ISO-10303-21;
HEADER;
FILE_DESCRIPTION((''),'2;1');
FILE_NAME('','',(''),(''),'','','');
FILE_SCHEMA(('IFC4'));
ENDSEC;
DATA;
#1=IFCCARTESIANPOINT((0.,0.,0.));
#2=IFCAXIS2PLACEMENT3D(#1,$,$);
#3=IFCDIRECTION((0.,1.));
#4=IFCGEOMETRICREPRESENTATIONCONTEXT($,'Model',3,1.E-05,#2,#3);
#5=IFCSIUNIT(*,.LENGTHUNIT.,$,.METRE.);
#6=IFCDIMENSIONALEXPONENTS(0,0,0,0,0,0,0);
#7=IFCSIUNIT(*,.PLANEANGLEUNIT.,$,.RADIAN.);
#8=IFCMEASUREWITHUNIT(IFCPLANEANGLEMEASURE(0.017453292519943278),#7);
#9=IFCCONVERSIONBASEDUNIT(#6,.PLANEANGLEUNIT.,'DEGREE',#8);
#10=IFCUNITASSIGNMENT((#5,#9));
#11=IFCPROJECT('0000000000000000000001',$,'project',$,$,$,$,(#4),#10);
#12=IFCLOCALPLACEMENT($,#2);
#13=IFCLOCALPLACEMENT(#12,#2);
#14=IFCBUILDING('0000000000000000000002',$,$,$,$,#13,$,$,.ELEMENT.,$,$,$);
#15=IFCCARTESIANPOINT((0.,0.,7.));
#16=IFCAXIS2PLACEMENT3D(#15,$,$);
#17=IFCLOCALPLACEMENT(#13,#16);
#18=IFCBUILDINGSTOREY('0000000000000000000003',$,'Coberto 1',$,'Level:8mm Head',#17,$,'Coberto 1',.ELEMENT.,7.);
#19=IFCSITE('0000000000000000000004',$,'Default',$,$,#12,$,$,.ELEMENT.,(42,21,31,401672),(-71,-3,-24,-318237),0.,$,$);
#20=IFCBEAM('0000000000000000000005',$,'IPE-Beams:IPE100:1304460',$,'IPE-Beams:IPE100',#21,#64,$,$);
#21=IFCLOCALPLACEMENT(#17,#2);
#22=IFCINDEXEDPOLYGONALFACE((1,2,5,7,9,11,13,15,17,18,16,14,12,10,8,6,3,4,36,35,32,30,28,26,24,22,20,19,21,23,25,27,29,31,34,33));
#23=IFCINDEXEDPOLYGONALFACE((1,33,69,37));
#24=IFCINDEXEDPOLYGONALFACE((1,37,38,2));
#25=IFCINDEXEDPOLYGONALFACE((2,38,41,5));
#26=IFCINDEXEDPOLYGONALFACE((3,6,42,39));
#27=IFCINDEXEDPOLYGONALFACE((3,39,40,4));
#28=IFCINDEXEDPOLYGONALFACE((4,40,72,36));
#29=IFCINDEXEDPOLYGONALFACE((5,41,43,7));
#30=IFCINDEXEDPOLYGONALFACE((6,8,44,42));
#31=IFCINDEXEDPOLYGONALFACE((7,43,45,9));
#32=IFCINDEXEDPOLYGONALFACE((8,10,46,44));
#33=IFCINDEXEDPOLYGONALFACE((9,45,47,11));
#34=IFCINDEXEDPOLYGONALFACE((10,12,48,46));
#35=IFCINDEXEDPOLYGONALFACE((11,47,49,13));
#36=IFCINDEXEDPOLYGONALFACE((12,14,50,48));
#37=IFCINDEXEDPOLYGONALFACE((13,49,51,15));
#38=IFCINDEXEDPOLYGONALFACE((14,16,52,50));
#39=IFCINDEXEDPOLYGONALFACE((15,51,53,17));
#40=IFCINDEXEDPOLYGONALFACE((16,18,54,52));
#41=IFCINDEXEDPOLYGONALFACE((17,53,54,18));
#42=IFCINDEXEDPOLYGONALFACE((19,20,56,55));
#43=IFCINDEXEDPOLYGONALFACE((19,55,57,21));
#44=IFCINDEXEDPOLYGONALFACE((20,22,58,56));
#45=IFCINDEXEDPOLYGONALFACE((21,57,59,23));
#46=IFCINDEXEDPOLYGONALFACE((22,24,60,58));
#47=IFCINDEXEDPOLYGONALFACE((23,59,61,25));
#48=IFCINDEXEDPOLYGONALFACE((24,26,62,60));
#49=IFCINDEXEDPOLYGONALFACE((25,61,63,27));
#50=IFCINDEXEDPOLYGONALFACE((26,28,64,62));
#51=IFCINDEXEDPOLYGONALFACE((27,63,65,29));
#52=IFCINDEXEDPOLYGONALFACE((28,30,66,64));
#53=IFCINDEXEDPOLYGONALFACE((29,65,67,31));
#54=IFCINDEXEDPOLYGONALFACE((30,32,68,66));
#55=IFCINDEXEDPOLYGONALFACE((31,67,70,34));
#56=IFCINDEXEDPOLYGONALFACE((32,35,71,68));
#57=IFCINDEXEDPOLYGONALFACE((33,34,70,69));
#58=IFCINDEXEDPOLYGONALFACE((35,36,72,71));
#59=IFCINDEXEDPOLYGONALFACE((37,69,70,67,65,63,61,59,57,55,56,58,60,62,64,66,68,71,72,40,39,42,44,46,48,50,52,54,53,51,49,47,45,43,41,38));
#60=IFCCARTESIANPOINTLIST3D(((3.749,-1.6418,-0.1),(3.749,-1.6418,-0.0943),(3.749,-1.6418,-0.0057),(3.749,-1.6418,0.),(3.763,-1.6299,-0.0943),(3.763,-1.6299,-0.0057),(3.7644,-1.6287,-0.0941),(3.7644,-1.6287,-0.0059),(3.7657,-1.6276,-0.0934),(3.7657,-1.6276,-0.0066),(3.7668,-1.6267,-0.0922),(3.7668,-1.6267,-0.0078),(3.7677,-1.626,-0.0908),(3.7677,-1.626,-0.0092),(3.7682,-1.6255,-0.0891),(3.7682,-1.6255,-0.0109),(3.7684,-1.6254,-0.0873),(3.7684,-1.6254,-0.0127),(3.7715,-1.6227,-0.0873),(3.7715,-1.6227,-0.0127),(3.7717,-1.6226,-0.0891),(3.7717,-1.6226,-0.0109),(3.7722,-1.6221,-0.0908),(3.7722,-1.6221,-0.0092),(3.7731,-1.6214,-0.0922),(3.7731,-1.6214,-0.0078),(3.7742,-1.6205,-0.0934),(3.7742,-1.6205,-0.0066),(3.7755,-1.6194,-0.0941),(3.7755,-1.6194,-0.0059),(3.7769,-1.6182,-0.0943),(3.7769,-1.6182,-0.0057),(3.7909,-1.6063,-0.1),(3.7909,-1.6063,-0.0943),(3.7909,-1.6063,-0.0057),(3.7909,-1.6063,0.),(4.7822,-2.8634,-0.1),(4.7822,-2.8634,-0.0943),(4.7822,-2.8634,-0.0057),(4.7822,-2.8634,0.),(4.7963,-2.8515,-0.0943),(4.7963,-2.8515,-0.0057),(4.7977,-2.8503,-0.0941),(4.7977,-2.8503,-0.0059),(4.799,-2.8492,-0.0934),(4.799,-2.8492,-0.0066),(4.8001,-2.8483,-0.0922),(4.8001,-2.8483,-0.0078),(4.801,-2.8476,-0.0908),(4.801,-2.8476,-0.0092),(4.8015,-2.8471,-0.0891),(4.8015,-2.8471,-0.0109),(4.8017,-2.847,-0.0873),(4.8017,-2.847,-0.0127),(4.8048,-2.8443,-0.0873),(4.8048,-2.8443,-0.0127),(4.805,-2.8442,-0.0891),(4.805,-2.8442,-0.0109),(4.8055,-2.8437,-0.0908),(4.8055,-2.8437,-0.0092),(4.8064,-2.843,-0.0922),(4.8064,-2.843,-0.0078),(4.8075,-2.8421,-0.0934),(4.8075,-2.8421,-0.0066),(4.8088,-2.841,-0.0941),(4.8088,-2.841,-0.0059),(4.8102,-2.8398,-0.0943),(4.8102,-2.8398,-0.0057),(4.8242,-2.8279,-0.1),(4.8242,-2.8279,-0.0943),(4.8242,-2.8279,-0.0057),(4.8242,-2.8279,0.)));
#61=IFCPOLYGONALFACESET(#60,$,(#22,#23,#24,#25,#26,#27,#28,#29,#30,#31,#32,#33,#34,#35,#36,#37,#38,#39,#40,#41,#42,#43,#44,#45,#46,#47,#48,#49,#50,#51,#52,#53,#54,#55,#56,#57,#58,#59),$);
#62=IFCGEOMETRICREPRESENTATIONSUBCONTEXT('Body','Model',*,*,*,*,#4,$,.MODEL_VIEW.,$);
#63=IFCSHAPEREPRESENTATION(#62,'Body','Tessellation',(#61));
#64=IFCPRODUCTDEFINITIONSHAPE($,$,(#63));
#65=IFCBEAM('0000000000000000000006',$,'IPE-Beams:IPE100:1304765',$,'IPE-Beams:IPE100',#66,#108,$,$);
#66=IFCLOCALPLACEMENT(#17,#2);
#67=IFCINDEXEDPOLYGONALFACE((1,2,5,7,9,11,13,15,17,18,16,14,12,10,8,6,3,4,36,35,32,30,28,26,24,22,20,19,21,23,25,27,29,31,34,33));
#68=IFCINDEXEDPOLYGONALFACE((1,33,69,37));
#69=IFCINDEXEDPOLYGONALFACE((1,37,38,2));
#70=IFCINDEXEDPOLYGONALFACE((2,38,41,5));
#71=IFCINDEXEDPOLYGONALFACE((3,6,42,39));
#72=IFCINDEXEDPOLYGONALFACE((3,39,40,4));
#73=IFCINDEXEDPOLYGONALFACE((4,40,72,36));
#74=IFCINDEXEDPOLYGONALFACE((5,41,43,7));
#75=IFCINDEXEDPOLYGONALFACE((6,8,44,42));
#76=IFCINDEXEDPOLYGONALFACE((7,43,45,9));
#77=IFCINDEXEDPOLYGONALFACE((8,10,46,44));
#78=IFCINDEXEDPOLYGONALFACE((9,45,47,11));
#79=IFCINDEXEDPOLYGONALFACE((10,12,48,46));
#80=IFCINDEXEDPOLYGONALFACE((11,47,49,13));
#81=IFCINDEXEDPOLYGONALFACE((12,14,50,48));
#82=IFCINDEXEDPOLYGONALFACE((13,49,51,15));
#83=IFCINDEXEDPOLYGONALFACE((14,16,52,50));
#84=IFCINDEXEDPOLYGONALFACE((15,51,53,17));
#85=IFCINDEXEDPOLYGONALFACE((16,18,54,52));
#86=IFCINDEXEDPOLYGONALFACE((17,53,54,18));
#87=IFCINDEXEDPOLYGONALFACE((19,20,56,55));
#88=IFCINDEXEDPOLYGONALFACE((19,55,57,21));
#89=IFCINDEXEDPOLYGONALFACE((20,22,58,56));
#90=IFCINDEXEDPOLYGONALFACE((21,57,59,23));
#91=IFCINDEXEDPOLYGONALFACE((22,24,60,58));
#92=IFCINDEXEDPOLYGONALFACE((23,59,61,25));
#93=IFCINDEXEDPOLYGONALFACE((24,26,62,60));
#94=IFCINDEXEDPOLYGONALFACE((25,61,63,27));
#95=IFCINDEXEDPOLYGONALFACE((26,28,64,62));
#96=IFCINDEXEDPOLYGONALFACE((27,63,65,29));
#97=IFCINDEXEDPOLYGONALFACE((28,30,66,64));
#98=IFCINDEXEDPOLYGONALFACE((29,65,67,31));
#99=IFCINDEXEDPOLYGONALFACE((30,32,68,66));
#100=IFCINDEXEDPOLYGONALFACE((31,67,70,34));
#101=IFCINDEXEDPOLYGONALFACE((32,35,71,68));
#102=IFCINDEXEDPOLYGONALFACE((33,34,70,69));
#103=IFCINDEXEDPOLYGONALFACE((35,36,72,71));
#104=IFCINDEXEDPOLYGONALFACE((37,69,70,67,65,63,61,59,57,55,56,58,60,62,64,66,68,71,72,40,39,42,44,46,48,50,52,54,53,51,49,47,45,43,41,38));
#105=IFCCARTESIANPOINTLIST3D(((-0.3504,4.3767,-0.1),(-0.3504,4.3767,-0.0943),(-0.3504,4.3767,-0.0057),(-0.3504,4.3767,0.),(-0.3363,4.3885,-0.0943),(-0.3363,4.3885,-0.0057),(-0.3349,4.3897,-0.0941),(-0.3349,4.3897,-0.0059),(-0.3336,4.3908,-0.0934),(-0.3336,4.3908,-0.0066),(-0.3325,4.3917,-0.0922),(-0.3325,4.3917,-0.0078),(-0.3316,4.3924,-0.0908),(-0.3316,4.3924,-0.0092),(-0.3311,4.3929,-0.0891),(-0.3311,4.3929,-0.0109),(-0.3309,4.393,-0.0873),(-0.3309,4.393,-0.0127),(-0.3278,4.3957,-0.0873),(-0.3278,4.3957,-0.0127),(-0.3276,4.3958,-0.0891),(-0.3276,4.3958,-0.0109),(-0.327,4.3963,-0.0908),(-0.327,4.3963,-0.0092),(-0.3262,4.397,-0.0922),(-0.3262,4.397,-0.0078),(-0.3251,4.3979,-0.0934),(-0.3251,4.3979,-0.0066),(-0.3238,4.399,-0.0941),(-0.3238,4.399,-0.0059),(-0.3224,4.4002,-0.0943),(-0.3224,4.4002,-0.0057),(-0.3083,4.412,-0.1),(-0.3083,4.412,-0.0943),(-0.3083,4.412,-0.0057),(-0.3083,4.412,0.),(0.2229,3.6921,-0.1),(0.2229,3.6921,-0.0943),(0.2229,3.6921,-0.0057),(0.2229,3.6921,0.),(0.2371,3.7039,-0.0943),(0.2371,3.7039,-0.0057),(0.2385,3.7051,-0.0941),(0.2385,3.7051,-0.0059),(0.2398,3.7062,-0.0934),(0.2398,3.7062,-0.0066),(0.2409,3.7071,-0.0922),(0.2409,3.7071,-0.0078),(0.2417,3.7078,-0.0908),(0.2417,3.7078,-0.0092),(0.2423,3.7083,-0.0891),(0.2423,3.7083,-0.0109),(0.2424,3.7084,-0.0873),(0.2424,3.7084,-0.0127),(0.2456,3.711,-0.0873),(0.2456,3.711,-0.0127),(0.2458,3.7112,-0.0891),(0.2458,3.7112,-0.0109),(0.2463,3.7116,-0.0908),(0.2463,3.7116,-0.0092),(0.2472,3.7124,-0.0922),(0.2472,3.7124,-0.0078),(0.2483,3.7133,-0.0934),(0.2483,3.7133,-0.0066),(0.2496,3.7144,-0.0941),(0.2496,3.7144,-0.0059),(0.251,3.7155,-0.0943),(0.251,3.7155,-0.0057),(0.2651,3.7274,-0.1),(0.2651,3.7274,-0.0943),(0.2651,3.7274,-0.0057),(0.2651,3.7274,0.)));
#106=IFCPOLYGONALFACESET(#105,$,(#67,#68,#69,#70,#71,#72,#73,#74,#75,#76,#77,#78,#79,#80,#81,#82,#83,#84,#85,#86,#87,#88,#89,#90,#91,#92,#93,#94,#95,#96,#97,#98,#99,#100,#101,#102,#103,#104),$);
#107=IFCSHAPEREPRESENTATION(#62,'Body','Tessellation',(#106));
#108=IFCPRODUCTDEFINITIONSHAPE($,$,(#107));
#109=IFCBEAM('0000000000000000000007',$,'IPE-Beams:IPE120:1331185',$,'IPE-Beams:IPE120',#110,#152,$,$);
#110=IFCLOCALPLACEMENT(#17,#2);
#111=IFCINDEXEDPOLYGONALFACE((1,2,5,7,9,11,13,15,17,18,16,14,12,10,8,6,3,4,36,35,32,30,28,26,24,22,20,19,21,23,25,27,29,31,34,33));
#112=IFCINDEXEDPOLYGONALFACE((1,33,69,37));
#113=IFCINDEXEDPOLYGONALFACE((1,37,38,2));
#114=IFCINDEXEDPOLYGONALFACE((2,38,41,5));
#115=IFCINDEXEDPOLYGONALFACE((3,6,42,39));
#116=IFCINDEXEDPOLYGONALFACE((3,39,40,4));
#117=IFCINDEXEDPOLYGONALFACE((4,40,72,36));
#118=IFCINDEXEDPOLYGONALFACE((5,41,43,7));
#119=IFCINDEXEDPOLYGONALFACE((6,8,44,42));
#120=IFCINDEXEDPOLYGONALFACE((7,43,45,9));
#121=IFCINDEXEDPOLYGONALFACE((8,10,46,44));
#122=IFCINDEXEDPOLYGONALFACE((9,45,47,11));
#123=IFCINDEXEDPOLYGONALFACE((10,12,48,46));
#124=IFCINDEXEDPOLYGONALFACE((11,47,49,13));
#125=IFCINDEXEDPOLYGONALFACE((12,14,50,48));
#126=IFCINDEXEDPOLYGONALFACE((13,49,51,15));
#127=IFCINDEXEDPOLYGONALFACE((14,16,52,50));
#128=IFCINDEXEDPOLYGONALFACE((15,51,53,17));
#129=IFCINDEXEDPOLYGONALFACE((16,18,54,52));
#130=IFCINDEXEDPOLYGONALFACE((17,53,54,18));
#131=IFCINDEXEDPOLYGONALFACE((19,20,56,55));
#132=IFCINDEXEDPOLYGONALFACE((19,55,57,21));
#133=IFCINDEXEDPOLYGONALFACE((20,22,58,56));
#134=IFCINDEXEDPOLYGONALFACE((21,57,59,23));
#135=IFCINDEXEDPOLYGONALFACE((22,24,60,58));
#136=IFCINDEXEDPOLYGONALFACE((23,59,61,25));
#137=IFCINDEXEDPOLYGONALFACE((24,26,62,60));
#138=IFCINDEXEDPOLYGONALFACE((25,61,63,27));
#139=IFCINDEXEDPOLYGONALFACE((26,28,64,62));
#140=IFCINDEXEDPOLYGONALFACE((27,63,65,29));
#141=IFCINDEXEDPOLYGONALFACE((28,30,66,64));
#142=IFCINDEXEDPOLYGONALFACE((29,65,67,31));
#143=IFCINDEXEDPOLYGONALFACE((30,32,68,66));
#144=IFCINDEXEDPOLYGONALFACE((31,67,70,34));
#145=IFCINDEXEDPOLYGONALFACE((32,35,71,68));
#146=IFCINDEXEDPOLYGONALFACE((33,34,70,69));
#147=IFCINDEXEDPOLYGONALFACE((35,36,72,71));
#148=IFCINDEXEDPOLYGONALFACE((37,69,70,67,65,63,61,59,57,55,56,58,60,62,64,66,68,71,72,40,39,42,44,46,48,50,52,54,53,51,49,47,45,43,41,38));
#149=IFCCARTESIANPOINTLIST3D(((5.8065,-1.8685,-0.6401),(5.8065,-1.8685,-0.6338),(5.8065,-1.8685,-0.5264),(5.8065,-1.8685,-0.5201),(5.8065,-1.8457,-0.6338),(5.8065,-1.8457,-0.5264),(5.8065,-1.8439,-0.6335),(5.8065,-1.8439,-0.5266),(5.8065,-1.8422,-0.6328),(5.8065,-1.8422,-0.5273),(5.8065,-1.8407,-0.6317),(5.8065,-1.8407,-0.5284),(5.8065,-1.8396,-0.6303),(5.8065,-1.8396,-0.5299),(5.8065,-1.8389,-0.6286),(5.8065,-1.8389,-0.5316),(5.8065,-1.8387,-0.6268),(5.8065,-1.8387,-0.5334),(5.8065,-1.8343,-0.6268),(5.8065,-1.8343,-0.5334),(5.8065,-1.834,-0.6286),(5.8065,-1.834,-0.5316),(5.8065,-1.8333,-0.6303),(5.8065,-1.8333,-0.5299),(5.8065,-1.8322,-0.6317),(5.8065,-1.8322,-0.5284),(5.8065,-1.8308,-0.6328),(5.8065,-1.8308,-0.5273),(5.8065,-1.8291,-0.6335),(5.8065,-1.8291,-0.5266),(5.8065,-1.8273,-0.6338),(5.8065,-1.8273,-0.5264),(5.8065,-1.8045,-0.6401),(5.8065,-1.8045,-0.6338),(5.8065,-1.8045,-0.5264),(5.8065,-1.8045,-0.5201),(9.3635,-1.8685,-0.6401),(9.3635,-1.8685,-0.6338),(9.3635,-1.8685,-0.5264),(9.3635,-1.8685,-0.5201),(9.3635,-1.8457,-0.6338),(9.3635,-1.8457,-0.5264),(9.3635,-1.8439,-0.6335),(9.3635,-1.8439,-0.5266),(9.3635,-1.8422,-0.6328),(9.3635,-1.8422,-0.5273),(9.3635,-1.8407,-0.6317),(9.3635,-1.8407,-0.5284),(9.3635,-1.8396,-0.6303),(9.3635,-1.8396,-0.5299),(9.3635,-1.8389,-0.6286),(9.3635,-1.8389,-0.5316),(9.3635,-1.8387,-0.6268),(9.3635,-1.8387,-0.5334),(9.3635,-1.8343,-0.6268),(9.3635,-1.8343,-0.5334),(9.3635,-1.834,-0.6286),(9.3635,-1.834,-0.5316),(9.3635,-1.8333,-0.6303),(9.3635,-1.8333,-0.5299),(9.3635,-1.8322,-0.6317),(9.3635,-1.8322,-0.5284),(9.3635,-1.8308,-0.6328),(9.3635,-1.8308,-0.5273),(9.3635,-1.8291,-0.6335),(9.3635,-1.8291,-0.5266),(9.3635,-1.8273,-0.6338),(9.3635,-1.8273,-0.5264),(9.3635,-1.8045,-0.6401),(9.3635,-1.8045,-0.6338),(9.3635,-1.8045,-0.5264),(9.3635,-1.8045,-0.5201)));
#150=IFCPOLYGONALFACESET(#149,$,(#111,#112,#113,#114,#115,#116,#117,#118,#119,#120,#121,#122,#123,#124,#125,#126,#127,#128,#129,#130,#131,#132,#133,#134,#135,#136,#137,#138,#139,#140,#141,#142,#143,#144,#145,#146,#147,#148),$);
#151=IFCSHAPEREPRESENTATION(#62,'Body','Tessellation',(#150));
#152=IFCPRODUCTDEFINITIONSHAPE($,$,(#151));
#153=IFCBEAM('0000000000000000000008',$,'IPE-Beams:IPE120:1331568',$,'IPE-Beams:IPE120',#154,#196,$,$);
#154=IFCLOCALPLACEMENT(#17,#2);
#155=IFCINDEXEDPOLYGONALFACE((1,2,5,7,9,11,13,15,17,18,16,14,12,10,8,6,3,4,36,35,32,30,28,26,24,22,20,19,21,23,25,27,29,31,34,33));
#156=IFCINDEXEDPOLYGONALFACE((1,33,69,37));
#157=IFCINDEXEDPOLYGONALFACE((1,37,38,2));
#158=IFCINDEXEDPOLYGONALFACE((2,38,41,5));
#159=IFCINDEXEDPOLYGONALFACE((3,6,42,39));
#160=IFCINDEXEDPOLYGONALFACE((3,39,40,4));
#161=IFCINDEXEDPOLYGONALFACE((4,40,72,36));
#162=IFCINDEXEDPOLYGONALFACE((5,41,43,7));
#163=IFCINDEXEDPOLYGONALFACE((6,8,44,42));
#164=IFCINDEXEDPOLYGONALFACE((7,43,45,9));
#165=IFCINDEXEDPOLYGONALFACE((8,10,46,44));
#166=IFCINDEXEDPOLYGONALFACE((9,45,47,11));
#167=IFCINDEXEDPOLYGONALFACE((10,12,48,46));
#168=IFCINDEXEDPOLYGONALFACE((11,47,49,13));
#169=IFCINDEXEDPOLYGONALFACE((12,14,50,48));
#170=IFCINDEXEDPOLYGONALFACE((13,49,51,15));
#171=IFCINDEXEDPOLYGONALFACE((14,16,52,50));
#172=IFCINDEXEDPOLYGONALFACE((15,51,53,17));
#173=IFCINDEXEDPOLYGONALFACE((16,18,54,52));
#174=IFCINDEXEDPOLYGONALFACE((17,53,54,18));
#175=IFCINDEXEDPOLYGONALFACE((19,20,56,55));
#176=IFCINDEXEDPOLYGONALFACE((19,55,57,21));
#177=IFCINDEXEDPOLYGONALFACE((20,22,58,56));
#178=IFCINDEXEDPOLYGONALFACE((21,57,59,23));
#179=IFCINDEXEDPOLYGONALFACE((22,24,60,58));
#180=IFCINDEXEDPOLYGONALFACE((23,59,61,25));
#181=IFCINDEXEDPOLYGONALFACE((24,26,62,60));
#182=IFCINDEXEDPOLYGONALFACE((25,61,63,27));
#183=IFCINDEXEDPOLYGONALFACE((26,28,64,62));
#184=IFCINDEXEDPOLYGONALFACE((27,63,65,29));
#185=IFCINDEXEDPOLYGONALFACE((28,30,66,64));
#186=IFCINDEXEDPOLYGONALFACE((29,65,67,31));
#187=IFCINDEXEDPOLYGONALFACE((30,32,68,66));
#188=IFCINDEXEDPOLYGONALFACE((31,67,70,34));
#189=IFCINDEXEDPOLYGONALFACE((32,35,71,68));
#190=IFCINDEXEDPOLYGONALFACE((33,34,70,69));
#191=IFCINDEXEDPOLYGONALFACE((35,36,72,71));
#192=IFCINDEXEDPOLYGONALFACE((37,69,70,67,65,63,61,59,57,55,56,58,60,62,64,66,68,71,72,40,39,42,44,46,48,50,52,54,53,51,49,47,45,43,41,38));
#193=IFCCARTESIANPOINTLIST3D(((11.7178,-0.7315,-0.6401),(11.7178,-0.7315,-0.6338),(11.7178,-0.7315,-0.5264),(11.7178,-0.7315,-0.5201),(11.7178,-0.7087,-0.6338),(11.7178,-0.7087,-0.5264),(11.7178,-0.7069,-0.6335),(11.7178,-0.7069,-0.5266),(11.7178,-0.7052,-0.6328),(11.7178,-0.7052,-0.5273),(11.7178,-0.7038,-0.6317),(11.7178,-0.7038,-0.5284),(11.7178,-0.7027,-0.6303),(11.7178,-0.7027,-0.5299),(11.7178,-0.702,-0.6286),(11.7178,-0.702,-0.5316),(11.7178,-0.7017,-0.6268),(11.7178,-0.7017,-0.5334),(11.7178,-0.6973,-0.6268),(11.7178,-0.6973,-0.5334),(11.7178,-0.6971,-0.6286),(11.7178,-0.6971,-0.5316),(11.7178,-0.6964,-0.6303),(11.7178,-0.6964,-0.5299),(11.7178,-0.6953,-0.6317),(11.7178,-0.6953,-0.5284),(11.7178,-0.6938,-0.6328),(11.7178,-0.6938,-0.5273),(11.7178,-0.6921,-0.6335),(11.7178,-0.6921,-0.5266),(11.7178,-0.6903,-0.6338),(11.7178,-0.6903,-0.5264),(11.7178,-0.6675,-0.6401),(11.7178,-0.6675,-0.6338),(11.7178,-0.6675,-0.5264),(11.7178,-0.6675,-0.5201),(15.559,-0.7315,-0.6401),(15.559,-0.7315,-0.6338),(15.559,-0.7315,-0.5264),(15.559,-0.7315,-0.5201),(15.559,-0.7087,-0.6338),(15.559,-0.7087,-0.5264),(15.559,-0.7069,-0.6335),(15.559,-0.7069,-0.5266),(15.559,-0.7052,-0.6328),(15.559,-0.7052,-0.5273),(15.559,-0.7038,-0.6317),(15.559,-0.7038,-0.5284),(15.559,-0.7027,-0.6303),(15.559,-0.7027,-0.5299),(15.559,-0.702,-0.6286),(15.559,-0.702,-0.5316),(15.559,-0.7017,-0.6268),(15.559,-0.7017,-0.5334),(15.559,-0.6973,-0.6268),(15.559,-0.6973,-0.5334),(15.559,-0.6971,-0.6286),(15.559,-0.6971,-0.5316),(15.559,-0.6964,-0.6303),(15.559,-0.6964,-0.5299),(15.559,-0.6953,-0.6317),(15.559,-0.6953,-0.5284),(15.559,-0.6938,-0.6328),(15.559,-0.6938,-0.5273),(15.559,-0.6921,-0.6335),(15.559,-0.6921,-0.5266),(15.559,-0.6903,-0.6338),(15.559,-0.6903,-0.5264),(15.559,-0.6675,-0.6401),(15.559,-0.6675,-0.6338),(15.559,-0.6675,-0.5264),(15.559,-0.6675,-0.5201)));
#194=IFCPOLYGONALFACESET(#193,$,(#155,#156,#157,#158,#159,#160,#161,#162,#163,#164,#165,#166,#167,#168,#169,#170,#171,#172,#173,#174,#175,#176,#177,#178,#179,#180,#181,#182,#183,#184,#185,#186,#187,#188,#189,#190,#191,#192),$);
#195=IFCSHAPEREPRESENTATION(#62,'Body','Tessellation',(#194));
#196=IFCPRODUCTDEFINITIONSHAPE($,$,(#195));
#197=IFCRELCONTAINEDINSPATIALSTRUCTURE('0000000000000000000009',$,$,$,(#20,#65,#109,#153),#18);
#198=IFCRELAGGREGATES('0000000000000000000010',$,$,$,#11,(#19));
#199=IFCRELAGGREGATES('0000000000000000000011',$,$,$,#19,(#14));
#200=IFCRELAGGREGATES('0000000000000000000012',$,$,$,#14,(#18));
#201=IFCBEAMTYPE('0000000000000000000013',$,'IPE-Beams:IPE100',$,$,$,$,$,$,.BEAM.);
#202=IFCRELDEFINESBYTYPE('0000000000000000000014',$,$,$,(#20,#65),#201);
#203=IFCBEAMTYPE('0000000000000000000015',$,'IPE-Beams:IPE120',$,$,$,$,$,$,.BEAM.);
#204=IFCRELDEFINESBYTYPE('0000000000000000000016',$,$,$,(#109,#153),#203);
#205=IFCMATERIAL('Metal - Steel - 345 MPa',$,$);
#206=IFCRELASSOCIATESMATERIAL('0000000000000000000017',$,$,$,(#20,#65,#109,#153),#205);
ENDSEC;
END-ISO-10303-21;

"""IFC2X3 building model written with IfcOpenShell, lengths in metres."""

from ifc_helpers import new_model, entity, si_unit, converted_unit, direction, frame, frame_2d, origin, place, context, subcontext, project, spatial, i_section, extrude, material, type_object, element, save


model = new_model("IFC2X3")

# Units and contexts
model_context = context("Model", 3, precision=1e-05, world=origin(), true_north=direction((0.0, 1.0)))
body_context = subcontext(model_context, "Body", "Model", "MODEL_VIEW")
ifc_project = project(units=[si_unit("LENGTHUNIT", "METRE"), converted_unit("PLANEANGLEUNIT", "DEGREE", entity("IfcPlaneAngleMeasure", 0.017453292519943278), si_unit("PLANEANGLEUNIT", "RADIAN"), dimensions=[0, 0, 0, 0, 0, 0, 0])], contexts=[model_context])

# Site, building, storey
site_placement = place(None, origin())
site = spatial("IfcSite", under=ifc_project, at=site_placement, Name="Default", CompositionType="ELEMENT", RefLatitude=(42, 21, 31, 401672), RefLongitude=(-71, -3, -24, -318237), RefElevation=0.0)
building_placement = place(site_placement, origin())
building = spatial("IfcBuilding", under=site, at=building_placement, CompositionType="ELEMENT")
storey_placement = place(building_placement, frame((0.0, 0.0, 7.0)))
storey = spatial("IfcBuildingStorey", under=building, at=storey_placement, Name="Coberto 1", ObjectType="Level:8mm Head", LongName="Coberto 1", CompositionType="ELEMENT", Elevation=7.0)

# Shared definitions
ifc_material_1 = material(Name="Metal - Steel - 345 MPa")

# Beams
beam_type_1 = type_object("IfcBeamType", Name="IPE-Beams:IPE100", PredefinedType="BEAM")
beam_1_placement = place(storey_placement, frame((3.7067, -1.5493, 0.0), z_axis=(0.0, 0.0, 1.0), x_axis=(0.645807, -0.763501, 0.0)))
element("IfcBeam", 1, at=beam_1_placement, inside=storey, type_object=beam_type_1, material=ifc_material_1, Name="IPE-Beams:IPE100:1304460", ObjectType="IPE-Beams:IPE100", context=body_context, shape_type="SweptSolid", body=[
    extrude(i_section(OverallWidth=0.055, OverallDepth=0.1, WebThickness=0.0041, FlangeThickness=0.0057, FilletRadius=0.007, at=frame_2d((0.0, 0.0), x_axis=(0.0, 1.0))), frame((0.0979, 0.0, -0.05), z_axis=(1.0, 0.0, 0.0), x_axis=(0.0, 0.0, -1.0)), (0.0, 0.0, 1.0), 1.6),
])
beam_2_placement = place(storey_placement, frame((0.3067, 3.6349, 0.0), z_axis=(0.0, 0.0, 1.0), x_axis=(-0.642048, 0.766664, 0.0)))
element("IfcBeam", 2, at=beam_2_placement, inside=storey, type_object=beam_type_1, material=ifc_material_1, Name="IPE-Beams:IPE100:1304765", ObjectType="IPE-Beams:IPE100", context=body_context, shape_type="SweptSolid", body=[
    extrude(i_section(OverallWidth=0.055, OverallDepth=0.1, WebThickness=0.0041, FlangeThickness=0.0057, FilletRadius=0.007, at=frame_2d((0.0, 0.0), x_axis=(0.0, 1.0))), frame((0.0976, 0.0, -0.05), z_axis=(1.0, 0.0, 0.0), x_axis=(0.0, 0.0, -1.0)), (0.0, 0.0, 1.0), 0.893),
])
beam_type_2 = type_object("IfcBeamType", Name="IPE-Beams:IPE120", PredefinedType="BEAM")
beam_3_placement = place(storey_placement, frame((5.8465, -1.8365, -0.5801)))
element("IfcBeam", 3, at=beam_3_placement, inside=storey, type_object=beam_type_2, material=ifc_material_1, Name="IPE-Beams:IPE120:1331185", ObjectType="IPE-Beams:IPE120", context=body_context, shape_type="SweptSolid", body=[
    extrude(i_section(OverallWidth=0.064, OverallDepth=0.12, WebThickness=0.0044, FlangeThickness=0.0063, FilletRadius=0.007, at=frame_2d((0.0, 0.0), x_axis=(0.0, 1.0))), frame((-0.04, 0.0, 0.0), z_axis=(1.0, 0.0, 0.0), x_axis=(0.0, 0.0, -1.0)), (0.0, 0.0, 1.0), 3.557),
])
beam_4_placement = place(storey_placement, frame((11.6176, -0.6995, -0.5801)))
element("IfcBeam", 4, at=beam_4_placement, inside=storey, type_object=beam_type_2, material=ifc_material_1, Name="IPE-Beams:IPE120:1331568", ObjectType="IPE-Beams:IPE120", context=body_context, shape_type="SweptSolid", body=[
    extrude(i_section(OverallWidth=0.064, OverallDepth=0.12, WebThickness=0.0044, FlangeThickness=0.0063, FilletRadius=0.007, at=frame_2d((0.0, 0.0), x_axis=(0.0, 1.0))), frame((0.1002, 0.0, 0.0), z_axis=(1.0, 0.0, 0.0), x_axis=(0.0, 0.0, -1.0)), (0.0, 0.0, 1.0), 3.8412),
])

save(model, "model.ifc")
